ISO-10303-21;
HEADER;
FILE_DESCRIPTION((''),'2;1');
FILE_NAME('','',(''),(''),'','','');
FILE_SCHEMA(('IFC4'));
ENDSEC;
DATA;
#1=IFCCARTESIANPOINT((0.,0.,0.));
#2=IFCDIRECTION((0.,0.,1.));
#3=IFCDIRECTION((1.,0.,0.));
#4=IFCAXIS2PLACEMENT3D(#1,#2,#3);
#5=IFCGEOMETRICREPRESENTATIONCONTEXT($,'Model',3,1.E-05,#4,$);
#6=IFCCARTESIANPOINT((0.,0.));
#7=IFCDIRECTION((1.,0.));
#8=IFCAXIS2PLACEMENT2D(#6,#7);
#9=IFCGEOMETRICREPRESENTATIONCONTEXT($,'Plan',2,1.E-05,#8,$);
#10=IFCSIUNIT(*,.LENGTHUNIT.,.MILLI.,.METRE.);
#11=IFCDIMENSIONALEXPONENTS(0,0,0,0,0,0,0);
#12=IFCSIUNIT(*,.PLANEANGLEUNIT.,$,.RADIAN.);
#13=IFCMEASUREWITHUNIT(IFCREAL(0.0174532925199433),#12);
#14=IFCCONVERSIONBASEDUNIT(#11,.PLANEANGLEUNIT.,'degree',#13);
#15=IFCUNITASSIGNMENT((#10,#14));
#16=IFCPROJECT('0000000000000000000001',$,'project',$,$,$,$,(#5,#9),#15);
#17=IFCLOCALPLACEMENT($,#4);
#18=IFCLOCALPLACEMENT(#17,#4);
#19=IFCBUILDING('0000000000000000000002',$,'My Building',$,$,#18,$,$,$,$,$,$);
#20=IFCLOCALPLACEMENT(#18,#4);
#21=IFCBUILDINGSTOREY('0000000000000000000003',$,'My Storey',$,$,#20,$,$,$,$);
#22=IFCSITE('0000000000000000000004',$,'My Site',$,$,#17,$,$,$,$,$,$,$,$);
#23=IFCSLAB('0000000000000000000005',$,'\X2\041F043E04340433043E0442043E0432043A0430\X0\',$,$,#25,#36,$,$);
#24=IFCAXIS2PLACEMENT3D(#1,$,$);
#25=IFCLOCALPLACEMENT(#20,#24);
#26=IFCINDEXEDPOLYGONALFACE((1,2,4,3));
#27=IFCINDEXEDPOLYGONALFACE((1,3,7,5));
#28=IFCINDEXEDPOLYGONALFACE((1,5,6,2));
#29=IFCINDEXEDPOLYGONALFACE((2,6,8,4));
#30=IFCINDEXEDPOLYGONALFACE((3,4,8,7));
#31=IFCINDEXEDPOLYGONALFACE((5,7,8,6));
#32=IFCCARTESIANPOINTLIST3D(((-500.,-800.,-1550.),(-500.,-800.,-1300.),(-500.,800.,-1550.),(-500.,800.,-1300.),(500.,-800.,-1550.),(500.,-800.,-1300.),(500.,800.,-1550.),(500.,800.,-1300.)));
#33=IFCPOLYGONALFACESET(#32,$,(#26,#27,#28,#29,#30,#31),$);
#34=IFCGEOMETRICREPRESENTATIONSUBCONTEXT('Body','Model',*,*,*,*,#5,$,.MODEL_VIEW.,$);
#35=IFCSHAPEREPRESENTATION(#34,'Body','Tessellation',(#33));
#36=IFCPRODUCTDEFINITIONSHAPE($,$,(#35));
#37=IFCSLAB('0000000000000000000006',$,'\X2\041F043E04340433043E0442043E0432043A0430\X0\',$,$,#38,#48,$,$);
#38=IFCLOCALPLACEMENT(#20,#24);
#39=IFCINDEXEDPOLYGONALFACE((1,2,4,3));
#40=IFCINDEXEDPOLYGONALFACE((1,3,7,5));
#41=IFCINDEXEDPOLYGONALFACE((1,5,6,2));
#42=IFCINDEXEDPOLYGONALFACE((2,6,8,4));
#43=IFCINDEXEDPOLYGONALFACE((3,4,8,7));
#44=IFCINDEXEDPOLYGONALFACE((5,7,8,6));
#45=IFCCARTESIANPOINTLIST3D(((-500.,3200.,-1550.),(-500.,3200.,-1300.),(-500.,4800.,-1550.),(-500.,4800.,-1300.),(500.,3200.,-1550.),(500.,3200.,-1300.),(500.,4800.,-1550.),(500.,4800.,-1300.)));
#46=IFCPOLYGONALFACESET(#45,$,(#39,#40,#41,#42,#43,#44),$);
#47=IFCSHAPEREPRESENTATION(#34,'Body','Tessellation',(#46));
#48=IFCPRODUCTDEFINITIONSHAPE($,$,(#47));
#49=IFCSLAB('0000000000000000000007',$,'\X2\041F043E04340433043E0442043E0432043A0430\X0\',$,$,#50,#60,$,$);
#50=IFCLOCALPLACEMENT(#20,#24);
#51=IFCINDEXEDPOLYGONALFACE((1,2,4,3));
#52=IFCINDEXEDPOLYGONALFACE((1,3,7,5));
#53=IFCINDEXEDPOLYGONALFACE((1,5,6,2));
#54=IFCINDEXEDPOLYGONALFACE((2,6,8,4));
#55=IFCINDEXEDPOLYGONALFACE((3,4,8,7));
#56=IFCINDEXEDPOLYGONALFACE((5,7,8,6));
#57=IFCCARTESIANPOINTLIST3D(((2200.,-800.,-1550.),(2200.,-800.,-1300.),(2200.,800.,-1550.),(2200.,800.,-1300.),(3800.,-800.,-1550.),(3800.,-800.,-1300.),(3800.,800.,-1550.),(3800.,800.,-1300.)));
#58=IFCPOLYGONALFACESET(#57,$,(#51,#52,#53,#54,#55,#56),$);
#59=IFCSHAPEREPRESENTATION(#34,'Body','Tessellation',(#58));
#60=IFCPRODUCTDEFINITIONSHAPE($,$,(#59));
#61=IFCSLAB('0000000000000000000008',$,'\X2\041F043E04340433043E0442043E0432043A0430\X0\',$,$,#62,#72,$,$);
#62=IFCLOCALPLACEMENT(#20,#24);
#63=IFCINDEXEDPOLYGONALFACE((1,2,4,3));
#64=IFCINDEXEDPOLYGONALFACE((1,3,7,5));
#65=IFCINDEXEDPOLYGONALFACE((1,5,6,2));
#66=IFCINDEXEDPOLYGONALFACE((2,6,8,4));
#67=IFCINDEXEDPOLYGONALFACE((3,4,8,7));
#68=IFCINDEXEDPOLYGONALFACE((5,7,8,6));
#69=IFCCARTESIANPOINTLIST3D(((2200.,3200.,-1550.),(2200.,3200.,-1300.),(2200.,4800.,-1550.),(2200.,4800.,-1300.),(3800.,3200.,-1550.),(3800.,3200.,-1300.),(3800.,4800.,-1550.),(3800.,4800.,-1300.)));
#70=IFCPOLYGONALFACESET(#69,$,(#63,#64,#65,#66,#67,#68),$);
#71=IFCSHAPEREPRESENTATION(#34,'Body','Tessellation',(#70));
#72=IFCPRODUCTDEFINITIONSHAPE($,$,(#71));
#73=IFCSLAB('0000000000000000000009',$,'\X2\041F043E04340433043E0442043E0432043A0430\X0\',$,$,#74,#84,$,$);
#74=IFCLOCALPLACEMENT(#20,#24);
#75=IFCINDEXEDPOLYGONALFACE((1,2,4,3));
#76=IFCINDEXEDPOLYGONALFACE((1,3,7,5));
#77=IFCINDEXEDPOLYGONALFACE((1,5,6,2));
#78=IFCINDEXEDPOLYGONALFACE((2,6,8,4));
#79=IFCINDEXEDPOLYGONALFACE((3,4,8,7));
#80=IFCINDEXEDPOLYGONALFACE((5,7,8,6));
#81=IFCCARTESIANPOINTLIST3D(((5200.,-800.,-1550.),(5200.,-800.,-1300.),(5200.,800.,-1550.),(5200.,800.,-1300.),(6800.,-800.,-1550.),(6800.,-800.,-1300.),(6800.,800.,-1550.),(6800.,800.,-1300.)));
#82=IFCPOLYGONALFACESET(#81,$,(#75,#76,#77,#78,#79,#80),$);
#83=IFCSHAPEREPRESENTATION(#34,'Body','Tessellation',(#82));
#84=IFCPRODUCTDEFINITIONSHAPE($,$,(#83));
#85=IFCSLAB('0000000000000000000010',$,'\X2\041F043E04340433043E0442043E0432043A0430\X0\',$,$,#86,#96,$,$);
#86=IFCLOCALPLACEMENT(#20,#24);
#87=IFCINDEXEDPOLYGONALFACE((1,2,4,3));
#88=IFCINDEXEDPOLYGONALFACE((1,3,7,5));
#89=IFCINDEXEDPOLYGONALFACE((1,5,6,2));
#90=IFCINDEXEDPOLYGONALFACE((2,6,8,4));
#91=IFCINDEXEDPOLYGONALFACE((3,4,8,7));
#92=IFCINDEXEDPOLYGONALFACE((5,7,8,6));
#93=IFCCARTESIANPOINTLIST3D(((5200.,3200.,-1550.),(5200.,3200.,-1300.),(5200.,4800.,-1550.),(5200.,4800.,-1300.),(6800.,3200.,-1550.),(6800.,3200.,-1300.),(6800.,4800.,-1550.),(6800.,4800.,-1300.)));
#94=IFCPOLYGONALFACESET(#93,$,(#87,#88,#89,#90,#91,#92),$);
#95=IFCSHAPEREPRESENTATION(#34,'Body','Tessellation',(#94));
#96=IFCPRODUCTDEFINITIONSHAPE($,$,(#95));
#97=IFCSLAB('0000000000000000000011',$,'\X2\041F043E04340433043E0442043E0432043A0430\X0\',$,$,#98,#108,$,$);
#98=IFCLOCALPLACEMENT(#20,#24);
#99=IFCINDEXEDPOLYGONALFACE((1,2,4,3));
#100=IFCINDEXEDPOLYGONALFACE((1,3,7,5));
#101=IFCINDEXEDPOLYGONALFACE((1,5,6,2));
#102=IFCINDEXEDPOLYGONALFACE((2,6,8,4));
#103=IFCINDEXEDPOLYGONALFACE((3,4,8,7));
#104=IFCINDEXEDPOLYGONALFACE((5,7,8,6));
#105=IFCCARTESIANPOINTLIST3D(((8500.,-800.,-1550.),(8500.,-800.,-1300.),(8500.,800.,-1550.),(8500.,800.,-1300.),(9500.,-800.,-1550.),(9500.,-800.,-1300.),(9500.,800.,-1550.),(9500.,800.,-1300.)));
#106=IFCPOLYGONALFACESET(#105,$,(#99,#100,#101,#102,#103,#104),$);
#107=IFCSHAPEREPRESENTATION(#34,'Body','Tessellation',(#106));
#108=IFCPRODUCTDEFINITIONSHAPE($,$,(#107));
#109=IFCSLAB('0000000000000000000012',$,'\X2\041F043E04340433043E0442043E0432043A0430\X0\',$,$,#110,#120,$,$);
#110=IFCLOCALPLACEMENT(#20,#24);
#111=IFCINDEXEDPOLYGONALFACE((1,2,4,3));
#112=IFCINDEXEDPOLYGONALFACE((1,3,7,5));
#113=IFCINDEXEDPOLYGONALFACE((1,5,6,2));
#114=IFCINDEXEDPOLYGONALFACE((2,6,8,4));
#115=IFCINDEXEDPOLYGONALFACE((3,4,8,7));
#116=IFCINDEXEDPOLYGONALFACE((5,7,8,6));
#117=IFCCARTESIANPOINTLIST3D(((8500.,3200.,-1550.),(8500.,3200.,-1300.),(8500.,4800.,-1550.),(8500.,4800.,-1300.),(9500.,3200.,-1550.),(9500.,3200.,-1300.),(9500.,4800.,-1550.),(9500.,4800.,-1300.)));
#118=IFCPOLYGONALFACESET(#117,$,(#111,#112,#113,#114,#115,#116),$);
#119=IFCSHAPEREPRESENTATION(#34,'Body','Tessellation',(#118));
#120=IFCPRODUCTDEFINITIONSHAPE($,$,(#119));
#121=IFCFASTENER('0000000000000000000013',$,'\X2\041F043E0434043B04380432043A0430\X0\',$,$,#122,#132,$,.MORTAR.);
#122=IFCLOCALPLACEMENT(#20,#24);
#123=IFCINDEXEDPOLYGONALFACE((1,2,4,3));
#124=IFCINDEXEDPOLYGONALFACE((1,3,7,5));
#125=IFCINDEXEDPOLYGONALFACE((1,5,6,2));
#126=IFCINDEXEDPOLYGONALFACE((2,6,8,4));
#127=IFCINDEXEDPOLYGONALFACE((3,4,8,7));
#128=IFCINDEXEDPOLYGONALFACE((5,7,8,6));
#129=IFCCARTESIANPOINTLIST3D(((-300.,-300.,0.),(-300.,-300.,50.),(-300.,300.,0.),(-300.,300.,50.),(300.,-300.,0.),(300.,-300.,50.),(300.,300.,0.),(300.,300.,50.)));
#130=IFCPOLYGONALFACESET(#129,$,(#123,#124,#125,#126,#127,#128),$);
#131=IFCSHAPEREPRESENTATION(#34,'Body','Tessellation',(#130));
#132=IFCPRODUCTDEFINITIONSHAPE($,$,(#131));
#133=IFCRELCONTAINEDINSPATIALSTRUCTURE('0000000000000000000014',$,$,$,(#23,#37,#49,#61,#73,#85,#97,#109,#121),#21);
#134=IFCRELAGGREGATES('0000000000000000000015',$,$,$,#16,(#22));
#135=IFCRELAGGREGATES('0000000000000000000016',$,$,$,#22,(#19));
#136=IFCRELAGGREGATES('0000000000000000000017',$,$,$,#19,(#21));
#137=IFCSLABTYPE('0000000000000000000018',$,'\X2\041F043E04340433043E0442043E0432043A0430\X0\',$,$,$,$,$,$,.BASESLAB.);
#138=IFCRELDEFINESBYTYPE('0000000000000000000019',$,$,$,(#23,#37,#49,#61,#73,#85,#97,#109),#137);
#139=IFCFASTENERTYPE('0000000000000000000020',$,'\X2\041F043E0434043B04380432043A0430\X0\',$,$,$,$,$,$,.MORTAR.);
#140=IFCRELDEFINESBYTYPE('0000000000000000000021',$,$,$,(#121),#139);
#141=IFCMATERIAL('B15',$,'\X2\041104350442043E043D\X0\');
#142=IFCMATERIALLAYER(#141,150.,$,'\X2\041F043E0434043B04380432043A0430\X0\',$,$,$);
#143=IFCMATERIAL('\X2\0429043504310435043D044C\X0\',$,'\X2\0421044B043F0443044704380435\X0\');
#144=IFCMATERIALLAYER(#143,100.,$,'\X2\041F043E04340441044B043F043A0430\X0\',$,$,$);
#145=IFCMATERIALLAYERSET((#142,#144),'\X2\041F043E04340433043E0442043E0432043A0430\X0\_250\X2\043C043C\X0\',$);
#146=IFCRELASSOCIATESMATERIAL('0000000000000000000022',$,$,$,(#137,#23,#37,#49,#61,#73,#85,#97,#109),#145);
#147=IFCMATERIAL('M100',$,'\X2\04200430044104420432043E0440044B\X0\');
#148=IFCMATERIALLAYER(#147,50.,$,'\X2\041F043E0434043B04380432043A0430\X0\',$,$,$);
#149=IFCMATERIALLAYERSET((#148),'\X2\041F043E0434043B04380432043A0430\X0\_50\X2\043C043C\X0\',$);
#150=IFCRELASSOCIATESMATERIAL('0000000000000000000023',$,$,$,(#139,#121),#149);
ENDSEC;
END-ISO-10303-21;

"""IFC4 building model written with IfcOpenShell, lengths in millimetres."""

from ifc_helpers import new_model, entity, si_unit, converted_unit, frame, origin_with_axes, origin_2d_with_axis, place, context, subcontext, project, spatial, line, indexed_curve, outline, extrude, material, layer, layer_set, layer_usage, type_object, element, save


model = new_model("IFC4")

# Units and contexts
model_context = context("Model", 3, precision=1e-05, world=origin_with_axes())
plan_context = context("Plan", 2, precision=1e-05, world=origin_2d_with_axis())
body_context = subcontext(model_context, "Body", "Model", "MODEL_VIEW")
ifc_project = project(units=[si_unit("LENGTHUNIT", "METRE", prefix="MILLI"), converted_unit("PLANEANGLEUNIT", "degree", entity("IfcReal", 0.0174532925199433), si_unit("PLANEANGLEUNIT", "RADIAN"), dimensions=[0, 0, 0, 0, 0, 0, 0])], contexts=[model_context, plan_context])

# Site, building, storey
site_placement = place(None, origin_with_axes())
site = spatial("IfcSite", under=ifc_project, at=site_placement, Name="My Site")
building_placement = place(site_placement, origin_with_axes())
building = spatial("IfcBuilding", under=site, at=building_placement, Name="My Building")
storey_placement = place(building_placement, origin_with_axes())
storey = spatial("IfcBuildingStorey", under=building, at=storey_placement, Name="My Storey")

# Slabs
ifc_material_1 = material(Name="B15", Category="Бетон")
ifc_layer_1 = layer(ifc_material_1, 150.0, Name="Подливка")
ifc_material_2 = material(Name="Щебень", Category="Сыпучие")
ifc_layer_2 = layer(ifc_material_2, 100.0, Name="Подсыпка")
ifc_layer_set_1 = layer_set([ifc_layer_1, ifc_layer_2], Name="Подготовка_250мм")
ifc_layer_usage_1 = layer_usage(ifc_layer_set_1, "AXIS3", "NEGATIVE", 0.0)
slab_type = type_object("IfcSlabType", Name="Подготовка", PredefinedType="BASESLAB", material=ifc_layer_set_1)
slab_1_placement = place(storey_placement, frame((0.0, 0.0, -1550.0), z_axis=(0.0, 0.0, 1.0), x_axis=(1.0, 0.0, 0.0)))
element("IfcSlab", 1, at=slab_1_placement, inside=storey, type_object=slab_type, material=ifc_layer_usage_1, Name="Подготовка", context=body_context, shape_type="SweptSolid", body=[
    extrude(outline(indexed_curve([(-500.0, -800.0), (500.0, -800.0), (500.0, 800.0), (-500.0, 800.0)], segments=[line(3, 2), line(2, 1), line(1, 4), line(4, 3)], self_intersect=False)), None, (0.0, 0.0, 1.0), 250.0),
])
ifc_layer_usage_2 = layer_usage(ifc_layer_set_1, "AXIS3", "NEGATIVE", 0.0)
slab_2_placement = place(storey_placement, frame((0.0, 4000.0, -1550.0), z_axis=(0.0, 0.0, 1.0), x_axis=(1.0, 0.0, 0.0)))
element("IfcSlab", 2, at=slab_2_placement, inside=storey, type_object=slab_type, material=ifc_layer_usage_2, Name="Подготовка", context=body_context, shape_type="SweptSolid", body=[
    extrude(outline(indexed_curve([(-500.0, -800.0), (500.0, -800.0), (500.0, 800.0), (-500.0, 800.0)], segments=[line(3, 2), line(2, 1), line(1, 4), line(4, 3)], self_intersect=False)), None, (0.0, 0.0, 1.0), 250.0),
])
ifc_layer_usage_3 = layer_usage(ifc_layer_set_1, "AXIS3", "NEGATIVE", 0.0)
slab_3_placement = place(storey_placement, frame((3000.0, 0.0, -1550.0), z_axis=(0.0, 0.0, 1.0), x_axis=(1.0, 0.0, 0.0)))
element("IfcSlab", 3, at=slab_3_placement, inside=storey, type_object=slab_type, material=ifc_layer_usage_3, Name="Подготовка", context=body_context, shape_type="SweptSolid", body=[
    extrude(outline(indexed_curve([(800.0, 800.0), (800.0, -800.0), (-800.0, -800.0), (-800.0, 800.0)], segments=[line(3, 2), line(2, 1), line(1, 4), line(4, 3)], self_intersect=False)), None, (0.0, 0.0, 1.0), 250.0),
])
ifc_layer_usage_4 = layer_usage(ifc_layer_set_1, "AXIS3", "NEGATIVE", 0.0)
slab_4_placement = place(storey_placement, frame((3000.0, 4000.0, -1550.0), z_axis=(0.0, 0.0, 1.0), x_axis=(1.0, 0.0, 0.0)))
element("IfcSlab", 4, at=slab_4_placement, inside=storey, type_object=slab_type, material=ifc_layer_usage_4, Name="Подготовка", context=body_context, shape_type="SweptSolid", body=[
    extrude(outline(indexed_curve([(-800.0, -800.0), (800.0, -800.0), (800.0, 800.0), (-800.0, 800.0)], segments=[line(3, 2), line(2, 1), line(1, 4), line(4, 3)], self_intersect=False)), None, (0.0, 0.0, 1.0), 250.0),
])
ifc_layer_usage_5 = layer_usage(ifc_layer_set_1, "AXIS3", "NEGATIVE", 0.0)
slab_5_placement = place(storey_placement, frame((6000.0, 0.0, -1550.0), z_axis=(0.0, 0.0, 1.0), x_axis=(1.0, 0.0, 0.0)))
element("IfcSlab", 5, at=slab_5_placement, inside=storey, type_object=slab_type, material=ifc_layer_usage_5, Name="Подготовка", context=body_context, shape_type="SweptSolid", body=[
    extrude(outline(indexed_curve([(800.0, 800.0), (800.0, -800.0), (-800.0, -800.0), (-800.0, 800.0)], segments=[line(3, 2), line(2, 1), line(1, 4), line(4, 3)], self_intersect=False)), None, (0.0, 0.0, 1.0), 250.0),
])
ifc_layer_usage_6 = layer_usage(ifc_layer_set_1, "AXIS3", "NEGATIVE", 0.0)
slab_6_placement = place(storey_placement, frame((6000.0, 4000.0, -1550.0), z_axis=(0.0, 0.0, 1.0), x_axis=(1.0, 0.0, 0.0)))
element("IfcSlab", 6, at=slab_6_placement, inside=storey, type_object=slab_type, material=ifc_layer_usage_6, Name="Подготовка", context=body_context, shape_type="SweptSolid", body=[
    extrude(outline(indexed_curve([(800.0, 800.0), (800.0, -800.0), (-800.0, -800.0), (-800.0, 800.0)], segments=[line(3, 2), line(2, 1), line(1, 4), line(4, 3)], self_intersect=False)), None, (0.0, 0.0, 1.0), 250.0),
])
ifc_layer_usage_7 = layer_usage(ifc_layer_set_1, "AXIS3", "NEGATIVE", 0.0)
slab_7_placement = place(storey_placement, frame((9000.0, 0.0, -1550.0), z_axis=(0.0, 0.0, 1.0), x_axis=(1.0, 0.0, 0.0)))
element("IfcSlab", 7, at=slab_7_placement, inside=storey, type_object=slab_type, material=ifc_layer_usage_7, Name="Подготовка", context=body_context, shape_type="SweptSolid", body=[
    extrude(outline(indexed_curve([(500.0, 800.0), (500.0, -800.0), (-500.0, -800.0), (-500.0, 800.0)], segments=[line(3, 2), line(2, 1), line(1, 4), line(4, 3)], self_intersect=False)), None, (0.0, 0.0, 1.0), 250.0),
])
ifc_layer_usage_8 = layer_usage(ifc_layer_set_1, "AXIS3", "NEGATIVE", 0.0)
slab_8_placement = place(storey_placement, frame((9000.0, 4000.0, -1550.0), z_axis=(0.0, 0.0, 1.0), x_axis=(1.0, 0.0, 0.0)))
element("IfcSlab", 8, at=slab_8_placement, inside=storey, type_object=slab_type, material=ifc_layer_usage_8, Name="Подготовка", context=body_context, shape_type="SweptSolid", body=[
    extrude(outline(indexed_curve([(-500.0, -800.0), (500.0, -800.0), (500.0, 800.0), (-500.0, 800.0)], segments=[line(3, 2), line(2, 1), line(1, 4), line(4, 3)], self_intersect=False)), None, (0.0, 0.0, 1.0), 250.0),
])

# Fastener
ifc_material_3 = material(Name="M100", Category="Растворы")
ifc_layer_3 = layer(ifc_material_3, 50.0, Name="Подливка")
ifc_layer_set_2 = layer_set([ifc_layer_3], Name="Подливка_50мм")
ifc_layer_usage_9 = layer_usage(ifc_layer_set_2, "AXIS3", "POSITIVE", 0.0)
fastener_type = type_object("IfcFastenerType", Name="Подливка", PredefinedType="MORTAR", material=ifc_layer_set_2)
fastener_placement = place(storey_placement, origin_with_axes())
element("IfcFastener", 9, at=fastener_placement, inside=storey, type_object=fastener_type, material=ifc_layer_usage_9, Name="Подливка", PredefinedType="MORTAR", context=body_context, shape_type="SweptSolid", body=[
    extrude(outline(indexed_curve([(-300.0, -300.0), (300.0, -300.0), (300.0, 300.0), (-300.0, 300.0)], segments=[line(3, 2), line(2, 1), line(1, 4), line(4, 3)], self_intersect=False)), None, (0.0, 0.0, 1.0), 50.0),
])

save(model, "model.ifc")
